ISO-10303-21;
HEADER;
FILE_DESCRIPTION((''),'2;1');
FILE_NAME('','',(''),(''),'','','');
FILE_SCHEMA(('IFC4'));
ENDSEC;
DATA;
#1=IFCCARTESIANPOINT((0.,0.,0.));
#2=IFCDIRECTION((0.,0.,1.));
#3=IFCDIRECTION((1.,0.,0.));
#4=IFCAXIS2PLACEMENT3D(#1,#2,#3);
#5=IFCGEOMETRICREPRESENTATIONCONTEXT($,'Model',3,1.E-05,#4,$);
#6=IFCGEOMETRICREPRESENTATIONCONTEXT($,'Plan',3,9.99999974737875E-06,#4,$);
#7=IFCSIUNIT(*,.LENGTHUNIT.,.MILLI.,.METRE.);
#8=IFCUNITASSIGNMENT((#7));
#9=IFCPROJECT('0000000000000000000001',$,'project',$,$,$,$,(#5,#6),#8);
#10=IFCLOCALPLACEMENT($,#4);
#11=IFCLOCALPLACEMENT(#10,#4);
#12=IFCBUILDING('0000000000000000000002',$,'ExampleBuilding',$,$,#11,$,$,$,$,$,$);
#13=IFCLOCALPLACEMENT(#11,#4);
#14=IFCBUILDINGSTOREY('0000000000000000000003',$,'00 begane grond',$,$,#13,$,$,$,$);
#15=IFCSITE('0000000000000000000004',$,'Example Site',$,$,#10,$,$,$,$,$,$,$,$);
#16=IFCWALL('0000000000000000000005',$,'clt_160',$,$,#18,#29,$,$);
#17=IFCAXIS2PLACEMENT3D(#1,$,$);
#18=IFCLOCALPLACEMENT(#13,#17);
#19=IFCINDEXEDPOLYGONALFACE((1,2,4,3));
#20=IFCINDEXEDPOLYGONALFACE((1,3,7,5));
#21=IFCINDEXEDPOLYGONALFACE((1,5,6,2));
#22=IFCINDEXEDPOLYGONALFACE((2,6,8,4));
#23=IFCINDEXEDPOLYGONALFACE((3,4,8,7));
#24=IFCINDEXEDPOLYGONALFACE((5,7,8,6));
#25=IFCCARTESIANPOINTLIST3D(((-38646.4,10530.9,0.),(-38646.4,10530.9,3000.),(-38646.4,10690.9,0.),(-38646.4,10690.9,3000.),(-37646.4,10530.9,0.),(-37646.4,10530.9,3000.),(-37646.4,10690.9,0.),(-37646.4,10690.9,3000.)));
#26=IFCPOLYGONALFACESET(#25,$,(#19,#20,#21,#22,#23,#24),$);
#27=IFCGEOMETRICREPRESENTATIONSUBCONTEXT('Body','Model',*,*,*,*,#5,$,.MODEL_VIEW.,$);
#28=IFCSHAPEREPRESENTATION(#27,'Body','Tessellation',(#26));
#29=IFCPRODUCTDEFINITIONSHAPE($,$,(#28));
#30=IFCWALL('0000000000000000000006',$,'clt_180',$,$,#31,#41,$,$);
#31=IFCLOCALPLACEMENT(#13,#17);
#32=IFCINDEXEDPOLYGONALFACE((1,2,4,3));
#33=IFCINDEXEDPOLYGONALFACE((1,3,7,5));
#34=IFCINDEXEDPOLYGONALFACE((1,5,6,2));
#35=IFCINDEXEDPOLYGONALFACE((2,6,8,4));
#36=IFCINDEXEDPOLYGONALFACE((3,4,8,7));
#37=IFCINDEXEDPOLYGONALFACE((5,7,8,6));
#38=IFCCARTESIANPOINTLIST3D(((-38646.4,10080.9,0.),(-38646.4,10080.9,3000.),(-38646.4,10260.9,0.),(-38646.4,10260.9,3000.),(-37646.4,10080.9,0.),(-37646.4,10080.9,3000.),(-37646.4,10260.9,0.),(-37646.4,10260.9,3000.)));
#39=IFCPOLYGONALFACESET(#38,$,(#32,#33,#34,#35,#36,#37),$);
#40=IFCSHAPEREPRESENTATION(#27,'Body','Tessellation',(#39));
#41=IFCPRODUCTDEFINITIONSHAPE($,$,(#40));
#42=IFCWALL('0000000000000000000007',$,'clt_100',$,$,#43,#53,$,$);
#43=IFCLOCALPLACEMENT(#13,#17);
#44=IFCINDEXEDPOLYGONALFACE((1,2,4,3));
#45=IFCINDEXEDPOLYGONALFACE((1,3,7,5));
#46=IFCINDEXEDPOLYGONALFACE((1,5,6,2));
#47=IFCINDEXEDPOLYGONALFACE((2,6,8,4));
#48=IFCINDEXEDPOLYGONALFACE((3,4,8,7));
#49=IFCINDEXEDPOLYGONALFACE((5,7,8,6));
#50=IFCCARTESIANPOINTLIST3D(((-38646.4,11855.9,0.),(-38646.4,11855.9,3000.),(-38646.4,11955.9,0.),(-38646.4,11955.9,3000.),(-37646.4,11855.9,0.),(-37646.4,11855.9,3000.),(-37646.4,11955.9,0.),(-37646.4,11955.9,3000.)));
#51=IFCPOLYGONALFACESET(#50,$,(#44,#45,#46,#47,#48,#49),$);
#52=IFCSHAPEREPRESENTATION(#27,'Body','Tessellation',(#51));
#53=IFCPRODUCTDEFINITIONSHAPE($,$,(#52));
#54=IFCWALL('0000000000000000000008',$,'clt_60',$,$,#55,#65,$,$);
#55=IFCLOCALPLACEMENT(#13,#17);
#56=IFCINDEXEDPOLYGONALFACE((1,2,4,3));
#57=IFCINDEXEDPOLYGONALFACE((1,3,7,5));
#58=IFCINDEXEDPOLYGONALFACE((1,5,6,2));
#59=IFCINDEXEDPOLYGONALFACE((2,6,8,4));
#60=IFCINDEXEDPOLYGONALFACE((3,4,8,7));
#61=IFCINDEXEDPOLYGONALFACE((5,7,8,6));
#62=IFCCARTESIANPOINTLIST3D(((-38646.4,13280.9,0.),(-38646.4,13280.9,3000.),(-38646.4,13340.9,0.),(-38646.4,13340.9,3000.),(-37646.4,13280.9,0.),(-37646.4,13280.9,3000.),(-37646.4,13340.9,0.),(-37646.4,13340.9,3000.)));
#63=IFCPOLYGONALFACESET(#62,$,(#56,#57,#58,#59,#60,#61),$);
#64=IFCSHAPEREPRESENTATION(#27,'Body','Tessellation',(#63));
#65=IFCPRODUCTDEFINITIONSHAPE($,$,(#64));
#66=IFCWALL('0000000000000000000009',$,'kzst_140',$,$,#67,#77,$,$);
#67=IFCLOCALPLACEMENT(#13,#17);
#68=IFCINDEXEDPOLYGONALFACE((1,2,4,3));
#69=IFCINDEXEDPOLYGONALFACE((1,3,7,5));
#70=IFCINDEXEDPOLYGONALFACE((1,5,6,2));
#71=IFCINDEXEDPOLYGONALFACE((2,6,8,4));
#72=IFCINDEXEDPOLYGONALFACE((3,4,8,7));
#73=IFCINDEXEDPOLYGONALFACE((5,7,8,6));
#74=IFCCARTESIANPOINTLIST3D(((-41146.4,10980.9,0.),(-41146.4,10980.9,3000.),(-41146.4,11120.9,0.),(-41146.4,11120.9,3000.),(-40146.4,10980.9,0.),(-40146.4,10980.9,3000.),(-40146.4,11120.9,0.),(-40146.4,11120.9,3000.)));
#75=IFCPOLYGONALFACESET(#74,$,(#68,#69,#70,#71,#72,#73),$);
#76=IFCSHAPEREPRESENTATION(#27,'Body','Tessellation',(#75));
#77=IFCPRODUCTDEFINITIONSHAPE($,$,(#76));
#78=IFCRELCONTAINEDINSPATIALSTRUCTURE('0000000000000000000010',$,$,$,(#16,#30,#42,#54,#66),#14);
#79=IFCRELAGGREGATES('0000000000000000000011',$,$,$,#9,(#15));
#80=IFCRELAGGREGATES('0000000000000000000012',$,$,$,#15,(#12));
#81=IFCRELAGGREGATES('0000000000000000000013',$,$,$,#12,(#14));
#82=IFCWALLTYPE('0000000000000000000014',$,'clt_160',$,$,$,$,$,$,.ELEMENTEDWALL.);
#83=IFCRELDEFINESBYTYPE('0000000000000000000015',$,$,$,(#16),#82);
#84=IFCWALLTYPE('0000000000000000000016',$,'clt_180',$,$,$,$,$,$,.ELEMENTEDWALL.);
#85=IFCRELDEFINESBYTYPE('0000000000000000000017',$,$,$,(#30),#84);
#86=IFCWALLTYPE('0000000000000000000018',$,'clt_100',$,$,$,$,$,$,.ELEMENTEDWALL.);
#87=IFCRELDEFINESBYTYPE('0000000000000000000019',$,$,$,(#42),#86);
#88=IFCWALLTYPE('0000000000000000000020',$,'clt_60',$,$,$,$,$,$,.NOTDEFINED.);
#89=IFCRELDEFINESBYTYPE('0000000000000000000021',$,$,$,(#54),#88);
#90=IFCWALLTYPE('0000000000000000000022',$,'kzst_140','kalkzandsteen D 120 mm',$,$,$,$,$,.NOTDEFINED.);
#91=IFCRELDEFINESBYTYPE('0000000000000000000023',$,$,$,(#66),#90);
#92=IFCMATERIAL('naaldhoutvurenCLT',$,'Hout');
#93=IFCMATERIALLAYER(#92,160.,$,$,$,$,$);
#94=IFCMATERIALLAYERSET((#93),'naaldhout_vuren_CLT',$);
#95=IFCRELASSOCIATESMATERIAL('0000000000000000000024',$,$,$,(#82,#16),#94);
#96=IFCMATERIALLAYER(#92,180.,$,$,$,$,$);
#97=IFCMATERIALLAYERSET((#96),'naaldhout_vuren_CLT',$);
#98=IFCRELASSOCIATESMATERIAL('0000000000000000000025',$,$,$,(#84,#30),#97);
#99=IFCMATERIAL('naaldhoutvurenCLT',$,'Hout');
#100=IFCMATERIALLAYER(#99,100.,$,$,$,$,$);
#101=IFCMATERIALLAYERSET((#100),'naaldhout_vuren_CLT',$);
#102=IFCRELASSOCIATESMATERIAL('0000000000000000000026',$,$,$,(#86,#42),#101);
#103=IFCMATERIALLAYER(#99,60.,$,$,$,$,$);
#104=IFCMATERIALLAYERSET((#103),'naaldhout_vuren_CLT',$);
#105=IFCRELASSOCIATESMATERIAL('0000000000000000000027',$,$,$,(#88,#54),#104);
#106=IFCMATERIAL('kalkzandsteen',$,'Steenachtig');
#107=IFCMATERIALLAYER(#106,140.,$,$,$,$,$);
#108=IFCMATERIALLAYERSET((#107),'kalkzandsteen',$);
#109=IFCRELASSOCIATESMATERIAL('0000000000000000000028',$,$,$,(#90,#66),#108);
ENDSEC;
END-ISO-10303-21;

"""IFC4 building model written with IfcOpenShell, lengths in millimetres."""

from ifc_helpers import new_model, si_unit, frame, origin_with_axes, place, context, subcontext, project, spatial, indexed_curve, outline, extrude, material, layer, layer_set, layer_usage, type_object, element, save


model = new_model("IFC4")

# Units and contexts
model_context = context("Model", 3, precision=1e-05, world=origin_with_axes())
plan_context = context("Plan", 3, precision=9.99999974737875e-06, world=origin_with_axes())
body_context = subcontext(model_context, "Body", "Model", "MODEL_VIEW")
ifc_project = project(units=[si_unit("LENGTHUNIT", "METRE", prefix="MILLI")], contexts=[model_context, plan_context])

# Site, building, storey
site_placement = place(None, frame((0.0, 0.0, 0.0), z_axis=(0.0, 0.0, 1.0), x_axis=(1.0, 0.0, 0.0)))
site = spatial("IfcSite", under=ifc_project, at=site_placement, Name="Example Site")
building_placement = place(site_placement, frame((0.0, 0.0, 0.0), z_axis=(0.0, 0.0, 1.0), x_axis=(1.0, 0.0, 0.0)))
building = spatial("IfcBuilding", under=site, at=building_placement, Name="ExampleBuilding")
storey_placement = place(building_placement, frame((0.0, 0.0, 0.0), z_axis=(0.0, 0.0, 1.0), x_axis=(1.0, 0.0, 0.0)))
storey = spatial("IfcBuildingStorey", under=building, at=storey_placement, Name="00 begane grond")

# Walls
ifc_material_1 = material(Name="naaldhoutvurenCLT", Category="Hout")
ifc_material_2 = material(Name="naaldhoutvurenCLT", Category="Hout")
ifc_material_3 = material(Name="kalkzandsteen", Category="Steenachtig")
ifc_layer_1 = layer(ifc_material_2, 160.0)
ifc_layer_set_1 = layer_set([ifc_layer_1], Name="naaldhout_vuren_CLT")
ifc_layer_usage_1 = layer_usage(ifc_layer_set_1, "AXIS2", "POSITIVE", 0.0)
wall_type_1 = type_object("IfcWallType", Name="clt_160", PredefinedType="ELEMENTEDWALL", material=ifc_layer_set_1)
wall_1_placement = place(storey_placement, frame((-38646.4, 10530.9, 0.0), z_axis=(0.0, 0.0, 1.0), x_axis=(1.0, 0.0, 0.0)))
element("IfcWall", 1, at=wall_1_placement, inside=storey, type_object=wall_type_1, material=ifc_layer_usage_1, Name="clt_160", context=body_context, shape_type="SweptSolid", body=[
    extrude(outline(indexed_curve([(0.0, 0.0), (0.0, 160.0), (1000.0, 160.0), (1000.0, 0.0), (0.0, 0.0)], self_intersect=False)), origin_with_axes(), (0.0, 0.0, 1.0), 3000.0),
])
ifc_layer_2 = layer(ifc_material_2, 180.0)
ifc_layer_set_2 = layer_set([ifc_layer_2], Name="naaldhout_vuren_CLT")
ifc_layer_usage_2 = layer_usage(ifc_layer_set_2, "AXIS2", "POSITIVE", 0.0)
wall_type_2 = type_object("IfcWallType", Name="clt_180", PredefinedType="ELEMENTEDWALL", material=ifc_layer_set_2)
wall_2_placement = place(storey_placement, frame((-38646.4, 10080.9, 0.0), z_axis=(0.0, 0.0, 1.0), x_axis=(1.0, 0.0, 0.0)))
element("IfcWall", 2, at=wall_2_placement, inside=storey, type_object=wall_type_2, material=ifc_layer_usage_2, Name="clt_180", context=body_context, shape_type="SweptSolid", body=[
    extrude(outline(indexed_curve([(0.0, 0.0), (0.0, 180.0), (1000.0, 180.0), (1000.0, 0.0), (0.0, 0.0)], self_intersect=False)), origin_with_axes(), (0.0, 0.0, 1.0), 3000.0),
])
ifc_layer_3 = layer(ifc_material_1, 100.0)
ifc_layer_set_3 = layer_set([ifc_layer_3], Name="naaldhout_vuren_CLT")
ifc_layer_usage_3 = layer_usage(ifc_layer_set_3, "AXIS2", "POSITIVE", 0.0)
wall_type_3 = type_object("IfcWallType", Name="clt_100", PredefinedType="ELEMENTEDWALL", material=ifc_layer_set_3)
wall_3_placement = place(storey_placement, frame((-38646.4, 11855.9, 0.0), z_axis=(0.0, 0.0, 1.0), x_axis=(1.0, 0.0, 0.0)))
element("IfcWall", 3, at=wall_3_placement, inside=storey, type_object=wall_type_3, material=ifc_layer_usage_3, Name="clt_100", context=body_context, shape_type="SweptSolid", body=[
    extrude(outline(indexed_curve([(0.0, 0.0), (0.0, 100.0), (1000.0, 100.0), (1000.0, 0.0), (0.0, 0.0)], self_intersect=False)), origin_with_axes(), (0.0, 0.0, 1.0), 3000.0),
])
ifc_layer_4 = layer(ifc_material_1, 60.0)
ifc_layer_set_4 = layer_set([ifc_layer_4], Name="naaldhout_vuren_CLT")
ifc_layer_usage_4 = layer_usage(ifc_layer_set_4, "AXIS2", "POSITIVE", 0.0)
wall_type_4 = type_object("IfcWallType", Name="clt_60", PredefinedType="NOTDEFINED", material=ifc_layer_set_4)
wall_4_placement = place(storey_placement, frame((-38646.4, 13280.9, 0.0), z_axis=(0.0, 0.0, 1.0), x_axis=(1.0, 0.0, 0.0)))
element("IfcWall", 4, at=wall_4_placement, inside=storey, type_object=wall_type_4, material=ifc_layer_usage_4, Name="clt_60", context=body_context, shape_type="SweptSolid", body=[
    extrude(outline(indexed_curve([(0.0, 0.0), (0.0, 60.0), (1000.0, 60.0), (1000.0, 0.0), (0.0, 0.0)], self_intersect=False)), origin_with_axes(), (0.0, 0.0, 1.0), 3000.0),
])
ifc_layer_5 = layer(ifc_material_3, 140.0)
ifc_layer_set_5 = layer_set([ifc_layer_5], Name="kalkzandsteen")
ifc_layer_usage_5 = layer_usage(ifc_layer_set_5, "AXIS2", "POSITIVE", 0.0)
wall_type_5 = type_object("IfcWallType", Name="kzst_140", Description="kalkzandsteen D 120 mm", PredefinedType="NOTDEFINED", material=ifc_layer_set_5)
wall_5_placement = place(storey_placement, frame((-41146.4, 10980.9, 0.0), z_axis=(0.0, 0.0, 1.0), x_axis=(1.0, 0.0, 0.0)))
element("IfcWall", 5, at=wall_5_placement, inside=storey, type_object=wall_type_5, material=ifc_layer_usage_5, Name="kzst_140", context=body_context, shape_type="SweptSolid", body=[
    extrude(outline(indexed_curve([(0.0, 0.0), (0.0, 140.0), (1000.0, 140.0), (1000.0, 0.0), (0.0, 0.0)], self_intersect=False)), origin_with_axes(), (0.0, 0.0, 1.0), 3000.0),
])

save(model, "model.ifc")
